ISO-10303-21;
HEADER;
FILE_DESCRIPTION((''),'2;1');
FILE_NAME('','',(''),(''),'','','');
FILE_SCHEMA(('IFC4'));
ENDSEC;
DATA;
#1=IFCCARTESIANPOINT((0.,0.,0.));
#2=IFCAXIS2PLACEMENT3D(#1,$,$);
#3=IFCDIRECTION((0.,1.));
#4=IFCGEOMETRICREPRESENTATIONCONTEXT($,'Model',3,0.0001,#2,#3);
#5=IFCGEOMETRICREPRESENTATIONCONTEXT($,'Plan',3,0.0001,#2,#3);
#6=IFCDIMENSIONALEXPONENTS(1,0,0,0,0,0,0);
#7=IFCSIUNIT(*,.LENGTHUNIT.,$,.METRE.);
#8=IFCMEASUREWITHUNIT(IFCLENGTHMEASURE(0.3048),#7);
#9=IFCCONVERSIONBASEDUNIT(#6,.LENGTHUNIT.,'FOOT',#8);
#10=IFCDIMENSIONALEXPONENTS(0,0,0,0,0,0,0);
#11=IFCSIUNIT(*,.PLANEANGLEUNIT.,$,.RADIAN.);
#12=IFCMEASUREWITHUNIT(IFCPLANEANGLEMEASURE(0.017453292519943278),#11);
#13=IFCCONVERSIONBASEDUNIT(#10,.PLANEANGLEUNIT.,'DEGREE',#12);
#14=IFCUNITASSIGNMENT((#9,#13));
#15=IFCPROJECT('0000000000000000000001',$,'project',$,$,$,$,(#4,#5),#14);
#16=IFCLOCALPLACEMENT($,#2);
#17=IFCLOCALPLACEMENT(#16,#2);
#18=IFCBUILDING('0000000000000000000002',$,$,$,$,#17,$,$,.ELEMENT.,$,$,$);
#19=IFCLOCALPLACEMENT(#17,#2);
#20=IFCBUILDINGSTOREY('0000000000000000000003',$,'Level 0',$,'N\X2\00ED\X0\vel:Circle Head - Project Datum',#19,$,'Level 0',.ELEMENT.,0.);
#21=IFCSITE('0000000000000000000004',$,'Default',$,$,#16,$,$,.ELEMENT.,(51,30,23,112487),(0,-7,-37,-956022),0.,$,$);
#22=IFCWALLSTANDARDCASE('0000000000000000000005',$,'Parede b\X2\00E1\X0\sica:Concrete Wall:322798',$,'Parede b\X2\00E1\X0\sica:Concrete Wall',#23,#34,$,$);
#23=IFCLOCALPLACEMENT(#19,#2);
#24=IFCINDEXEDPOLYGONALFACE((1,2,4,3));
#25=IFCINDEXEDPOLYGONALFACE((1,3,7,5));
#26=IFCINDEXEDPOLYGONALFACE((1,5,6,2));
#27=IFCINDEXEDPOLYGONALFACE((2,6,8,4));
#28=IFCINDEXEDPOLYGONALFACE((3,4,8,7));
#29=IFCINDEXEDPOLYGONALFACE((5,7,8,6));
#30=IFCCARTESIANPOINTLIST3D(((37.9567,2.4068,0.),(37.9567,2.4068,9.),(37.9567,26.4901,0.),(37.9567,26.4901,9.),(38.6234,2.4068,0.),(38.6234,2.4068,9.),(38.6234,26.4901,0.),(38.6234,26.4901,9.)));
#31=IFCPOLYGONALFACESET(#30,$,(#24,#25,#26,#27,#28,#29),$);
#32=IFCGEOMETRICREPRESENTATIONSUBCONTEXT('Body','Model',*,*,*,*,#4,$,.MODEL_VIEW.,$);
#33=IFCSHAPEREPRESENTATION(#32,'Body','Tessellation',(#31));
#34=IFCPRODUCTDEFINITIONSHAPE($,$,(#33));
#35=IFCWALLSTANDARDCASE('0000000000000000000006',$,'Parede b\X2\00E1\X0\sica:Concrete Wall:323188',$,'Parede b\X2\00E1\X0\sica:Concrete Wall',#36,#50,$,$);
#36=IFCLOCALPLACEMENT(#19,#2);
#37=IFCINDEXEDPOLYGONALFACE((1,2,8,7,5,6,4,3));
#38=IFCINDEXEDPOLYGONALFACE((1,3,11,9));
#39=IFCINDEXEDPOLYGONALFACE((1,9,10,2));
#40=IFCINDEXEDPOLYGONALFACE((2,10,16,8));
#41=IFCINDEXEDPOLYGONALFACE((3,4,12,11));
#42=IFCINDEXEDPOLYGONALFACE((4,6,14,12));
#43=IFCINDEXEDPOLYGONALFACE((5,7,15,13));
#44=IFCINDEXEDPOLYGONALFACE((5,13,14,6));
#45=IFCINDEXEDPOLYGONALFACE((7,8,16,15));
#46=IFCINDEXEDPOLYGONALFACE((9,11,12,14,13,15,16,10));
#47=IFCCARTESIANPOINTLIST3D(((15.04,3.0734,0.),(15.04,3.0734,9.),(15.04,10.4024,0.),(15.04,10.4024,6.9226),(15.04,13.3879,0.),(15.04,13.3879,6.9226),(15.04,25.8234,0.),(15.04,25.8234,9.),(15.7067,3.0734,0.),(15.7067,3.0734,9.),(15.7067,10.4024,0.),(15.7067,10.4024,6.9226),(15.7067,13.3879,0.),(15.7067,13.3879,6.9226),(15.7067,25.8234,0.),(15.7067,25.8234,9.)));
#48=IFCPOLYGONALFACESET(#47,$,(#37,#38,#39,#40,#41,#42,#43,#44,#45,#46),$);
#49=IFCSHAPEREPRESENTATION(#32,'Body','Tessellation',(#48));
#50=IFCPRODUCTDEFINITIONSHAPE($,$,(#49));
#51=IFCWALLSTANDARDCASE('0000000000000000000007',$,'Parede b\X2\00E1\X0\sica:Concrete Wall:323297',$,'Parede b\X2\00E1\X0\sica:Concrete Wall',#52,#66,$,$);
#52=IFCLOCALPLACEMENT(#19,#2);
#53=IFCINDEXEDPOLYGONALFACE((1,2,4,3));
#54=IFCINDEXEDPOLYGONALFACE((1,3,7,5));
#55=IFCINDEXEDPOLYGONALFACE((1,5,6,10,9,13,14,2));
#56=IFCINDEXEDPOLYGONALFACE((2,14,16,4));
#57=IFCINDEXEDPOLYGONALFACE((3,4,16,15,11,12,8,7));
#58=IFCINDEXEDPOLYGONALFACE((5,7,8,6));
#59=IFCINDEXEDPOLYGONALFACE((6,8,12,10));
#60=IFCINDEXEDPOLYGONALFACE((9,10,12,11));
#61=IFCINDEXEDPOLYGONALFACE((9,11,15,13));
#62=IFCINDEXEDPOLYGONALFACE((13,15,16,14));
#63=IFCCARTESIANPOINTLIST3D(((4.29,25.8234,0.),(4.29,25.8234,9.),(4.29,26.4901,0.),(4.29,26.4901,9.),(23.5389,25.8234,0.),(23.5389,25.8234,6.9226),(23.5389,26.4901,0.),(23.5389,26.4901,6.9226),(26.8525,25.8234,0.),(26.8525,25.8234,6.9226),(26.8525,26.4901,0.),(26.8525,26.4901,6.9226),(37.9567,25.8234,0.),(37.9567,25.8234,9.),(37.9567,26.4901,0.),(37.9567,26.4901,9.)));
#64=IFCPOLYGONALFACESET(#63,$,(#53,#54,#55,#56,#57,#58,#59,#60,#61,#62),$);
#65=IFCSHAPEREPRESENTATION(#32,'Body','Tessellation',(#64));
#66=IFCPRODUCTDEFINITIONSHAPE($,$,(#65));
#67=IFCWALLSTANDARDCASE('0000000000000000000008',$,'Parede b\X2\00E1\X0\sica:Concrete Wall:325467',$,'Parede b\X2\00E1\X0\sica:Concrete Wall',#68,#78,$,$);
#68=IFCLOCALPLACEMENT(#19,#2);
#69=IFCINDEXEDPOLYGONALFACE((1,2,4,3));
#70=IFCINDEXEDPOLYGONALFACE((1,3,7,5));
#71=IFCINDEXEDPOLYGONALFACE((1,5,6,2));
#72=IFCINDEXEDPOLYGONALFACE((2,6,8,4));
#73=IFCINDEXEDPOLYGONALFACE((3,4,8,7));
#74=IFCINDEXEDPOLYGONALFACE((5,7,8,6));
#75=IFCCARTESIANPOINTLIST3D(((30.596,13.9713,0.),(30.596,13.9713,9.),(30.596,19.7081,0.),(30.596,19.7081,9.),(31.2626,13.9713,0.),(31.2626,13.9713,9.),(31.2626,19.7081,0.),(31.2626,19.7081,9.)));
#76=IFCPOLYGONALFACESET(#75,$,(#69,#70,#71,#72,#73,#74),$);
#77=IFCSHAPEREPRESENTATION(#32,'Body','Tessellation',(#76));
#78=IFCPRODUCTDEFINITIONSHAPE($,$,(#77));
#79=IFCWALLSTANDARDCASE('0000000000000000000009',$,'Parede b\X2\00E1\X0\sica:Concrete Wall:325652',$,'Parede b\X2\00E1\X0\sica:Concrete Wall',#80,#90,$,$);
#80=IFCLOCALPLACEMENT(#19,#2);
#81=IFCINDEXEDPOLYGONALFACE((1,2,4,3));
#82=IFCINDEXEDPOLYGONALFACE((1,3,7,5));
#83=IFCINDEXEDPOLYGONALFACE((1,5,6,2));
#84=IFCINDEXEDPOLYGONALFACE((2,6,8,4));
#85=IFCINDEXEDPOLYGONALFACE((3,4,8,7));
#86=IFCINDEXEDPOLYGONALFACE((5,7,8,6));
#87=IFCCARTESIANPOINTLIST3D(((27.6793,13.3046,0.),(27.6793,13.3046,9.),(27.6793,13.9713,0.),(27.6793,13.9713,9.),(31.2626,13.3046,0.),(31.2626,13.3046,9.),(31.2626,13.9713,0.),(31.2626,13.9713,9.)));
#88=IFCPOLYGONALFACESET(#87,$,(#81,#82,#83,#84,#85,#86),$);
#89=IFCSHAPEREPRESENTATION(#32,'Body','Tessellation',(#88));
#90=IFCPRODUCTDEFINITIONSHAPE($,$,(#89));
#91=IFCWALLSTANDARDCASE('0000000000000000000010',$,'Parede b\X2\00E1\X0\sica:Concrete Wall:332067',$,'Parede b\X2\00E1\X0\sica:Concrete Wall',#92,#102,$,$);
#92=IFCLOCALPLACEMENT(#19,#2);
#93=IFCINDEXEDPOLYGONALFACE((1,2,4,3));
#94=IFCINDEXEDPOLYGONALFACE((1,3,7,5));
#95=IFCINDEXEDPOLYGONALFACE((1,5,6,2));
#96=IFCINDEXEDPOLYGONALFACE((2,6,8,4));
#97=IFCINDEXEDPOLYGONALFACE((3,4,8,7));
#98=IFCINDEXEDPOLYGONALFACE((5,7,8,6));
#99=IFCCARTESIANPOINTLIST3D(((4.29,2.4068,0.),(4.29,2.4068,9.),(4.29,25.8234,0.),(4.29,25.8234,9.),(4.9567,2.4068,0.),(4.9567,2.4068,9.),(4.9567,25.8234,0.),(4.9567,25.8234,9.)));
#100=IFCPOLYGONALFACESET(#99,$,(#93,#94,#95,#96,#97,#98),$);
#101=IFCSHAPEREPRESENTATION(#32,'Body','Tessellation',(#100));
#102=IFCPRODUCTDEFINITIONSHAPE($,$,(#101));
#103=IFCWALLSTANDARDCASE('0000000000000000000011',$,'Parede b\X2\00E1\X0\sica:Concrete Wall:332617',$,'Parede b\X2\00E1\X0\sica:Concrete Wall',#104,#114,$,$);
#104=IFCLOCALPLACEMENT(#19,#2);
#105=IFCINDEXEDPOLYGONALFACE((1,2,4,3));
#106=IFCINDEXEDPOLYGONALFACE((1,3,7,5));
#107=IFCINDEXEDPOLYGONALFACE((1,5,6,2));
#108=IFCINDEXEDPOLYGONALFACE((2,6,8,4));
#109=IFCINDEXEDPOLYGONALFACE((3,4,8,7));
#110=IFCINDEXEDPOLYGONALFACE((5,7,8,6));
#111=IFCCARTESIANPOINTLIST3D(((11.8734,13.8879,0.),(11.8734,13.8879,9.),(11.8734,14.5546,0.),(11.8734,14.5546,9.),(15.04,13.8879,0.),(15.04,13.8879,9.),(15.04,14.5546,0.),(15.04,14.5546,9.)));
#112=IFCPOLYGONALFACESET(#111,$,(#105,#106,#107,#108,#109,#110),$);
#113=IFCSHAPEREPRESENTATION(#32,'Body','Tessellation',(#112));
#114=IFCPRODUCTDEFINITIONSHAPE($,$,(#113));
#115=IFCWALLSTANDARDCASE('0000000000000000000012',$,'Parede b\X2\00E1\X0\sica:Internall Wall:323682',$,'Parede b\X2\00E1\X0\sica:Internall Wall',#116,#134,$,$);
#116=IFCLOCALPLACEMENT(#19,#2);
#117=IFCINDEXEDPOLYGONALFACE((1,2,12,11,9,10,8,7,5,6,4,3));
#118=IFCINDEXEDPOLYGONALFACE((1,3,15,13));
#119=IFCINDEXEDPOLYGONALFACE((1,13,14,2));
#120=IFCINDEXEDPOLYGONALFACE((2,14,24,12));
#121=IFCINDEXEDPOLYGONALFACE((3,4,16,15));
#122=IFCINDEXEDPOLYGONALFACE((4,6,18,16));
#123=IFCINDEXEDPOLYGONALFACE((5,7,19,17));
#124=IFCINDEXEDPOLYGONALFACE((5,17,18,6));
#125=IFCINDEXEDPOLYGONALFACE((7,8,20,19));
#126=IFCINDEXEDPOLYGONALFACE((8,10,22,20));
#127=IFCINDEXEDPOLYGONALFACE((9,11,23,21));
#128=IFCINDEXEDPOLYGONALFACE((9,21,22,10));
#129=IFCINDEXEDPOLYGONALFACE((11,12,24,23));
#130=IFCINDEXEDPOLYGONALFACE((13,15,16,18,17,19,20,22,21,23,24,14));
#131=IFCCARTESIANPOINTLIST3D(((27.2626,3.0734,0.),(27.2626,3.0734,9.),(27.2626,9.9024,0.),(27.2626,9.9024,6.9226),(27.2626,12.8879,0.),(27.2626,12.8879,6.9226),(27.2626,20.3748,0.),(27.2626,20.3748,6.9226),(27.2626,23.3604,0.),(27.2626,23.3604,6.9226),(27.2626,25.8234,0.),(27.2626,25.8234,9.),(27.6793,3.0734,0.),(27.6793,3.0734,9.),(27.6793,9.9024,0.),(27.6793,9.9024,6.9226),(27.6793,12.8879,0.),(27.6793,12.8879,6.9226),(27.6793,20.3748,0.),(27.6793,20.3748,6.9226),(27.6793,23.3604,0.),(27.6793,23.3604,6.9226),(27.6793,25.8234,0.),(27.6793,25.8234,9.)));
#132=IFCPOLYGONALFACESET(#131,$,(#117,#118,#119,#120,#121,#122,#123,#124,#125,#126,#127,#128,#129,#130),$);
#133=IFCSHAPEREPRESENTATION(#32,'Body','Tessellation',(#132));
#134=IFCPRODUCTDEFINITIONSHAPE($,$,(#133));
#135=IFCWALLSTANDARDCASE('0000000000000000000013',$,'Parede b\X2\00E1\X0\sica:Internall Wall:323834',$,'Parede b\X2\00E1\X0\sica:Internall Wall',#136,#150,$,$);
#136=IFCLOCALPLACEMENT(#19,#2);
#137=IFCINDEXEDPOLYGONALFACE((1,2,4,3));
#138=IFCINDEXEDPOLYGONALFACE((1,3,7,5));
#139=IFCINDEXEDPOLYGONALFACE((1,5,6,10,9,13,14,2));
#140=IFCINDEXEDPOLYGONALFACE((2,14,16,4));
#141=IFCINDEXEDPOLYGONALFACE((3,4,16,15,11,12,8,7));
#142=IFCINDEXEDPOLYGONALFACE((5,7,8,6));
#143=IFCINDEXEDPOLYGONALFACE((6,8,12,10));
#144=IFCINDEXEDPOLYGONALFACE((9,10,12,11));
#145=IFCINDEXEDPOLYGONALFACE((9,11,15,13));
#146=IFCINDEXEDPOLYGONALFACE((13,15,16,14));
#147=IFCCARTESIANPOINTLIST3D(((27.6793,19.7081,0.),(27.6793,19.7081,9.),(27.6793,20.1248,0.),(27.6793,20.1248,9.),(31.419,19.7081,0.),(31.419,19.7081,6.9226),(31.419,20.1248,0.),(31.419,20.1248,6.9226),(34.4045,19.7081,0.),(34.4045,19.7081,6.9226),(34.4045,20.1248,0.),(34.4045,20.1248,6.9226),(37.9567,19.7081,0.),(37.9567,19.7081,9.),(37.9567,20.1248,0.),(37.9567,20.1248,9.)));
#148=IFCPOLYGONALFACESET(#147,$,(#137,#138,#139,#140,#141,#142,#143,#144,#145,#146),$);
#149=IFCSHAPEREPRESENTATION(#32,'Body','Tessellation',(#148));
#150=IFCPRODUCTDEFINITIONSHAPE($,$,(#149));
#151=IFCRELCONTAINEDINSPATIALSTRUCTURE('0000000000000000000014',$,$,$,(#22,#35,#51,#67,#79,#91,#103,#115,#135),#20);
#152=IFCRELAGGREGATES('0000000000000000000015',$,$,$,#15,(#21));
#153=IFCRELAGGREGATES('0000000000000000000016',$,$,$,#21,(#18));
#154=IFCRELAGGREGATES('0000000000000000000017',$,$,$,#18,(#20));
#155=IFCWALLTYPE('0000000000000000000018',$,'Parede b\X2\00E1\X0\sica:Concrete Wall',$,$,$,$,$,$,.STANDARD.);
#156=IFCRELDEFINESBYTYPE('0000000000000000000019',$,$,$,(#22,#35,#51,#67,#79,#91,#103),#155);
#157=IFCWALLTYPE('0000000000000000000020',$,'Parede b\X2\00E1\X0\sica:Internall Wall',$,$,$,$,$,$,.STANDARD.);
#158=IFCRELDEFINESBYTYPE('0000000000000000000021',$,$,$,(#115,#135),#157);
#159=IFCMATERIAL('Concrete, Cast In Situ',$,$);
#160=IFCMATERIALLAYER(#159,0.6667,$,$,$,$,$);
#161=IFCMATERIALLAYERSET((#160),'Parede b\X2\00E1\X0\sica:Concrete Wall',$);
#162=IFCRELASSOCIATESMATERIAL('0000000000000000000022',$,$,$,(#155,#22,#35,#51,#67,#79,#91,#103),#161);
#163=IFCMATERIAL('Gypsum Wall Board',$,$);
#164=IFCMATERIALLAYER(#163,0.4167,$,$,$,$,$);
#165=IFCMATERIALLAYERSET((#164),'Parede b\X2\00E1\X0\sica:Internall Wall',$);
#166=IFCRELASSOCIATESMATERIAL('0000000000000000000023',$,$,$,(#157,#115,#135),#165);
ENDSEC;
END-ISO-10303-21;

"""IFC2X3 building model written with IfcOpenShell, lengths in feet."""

from ifc_helpers import new_model, entity, si_unit, converted_unit, direction, frame, frame_2d, origin, place, context, subcontext, project, spatial, rectangle, extrude, material, layer, layer_set, layer_usage, type_object, element, save


model = new_model("IFC2X3")

# Units and contexts
model_context = context("Model", 3, precision=0.0001, world=origin(), true_north=direction((0.0, 1.0)))
plan_context = context("Plan", 3, precision=0.0001, world=origin(), true_north=direction((0.0, 1.0)))
body_context = subcontext(model_context, "Body", "Model", "MODEL_VIEW")
ifc_project = project(units=[converted_unit("LENGTHUNIT", "FOOT", entity("IfcLengthMeasure", 0.3048), si_unit("LENGTHUNIT", "METRE"), dimensions=[1, 0, 0, 0, 0, 0, 0]), converted_unit("PLANEANGLEUNIT", "DEGREE", entity("IfcPlaneAngleMeasure", 0.017453292519943278), si_unit("PLANEANGLEUNIT", "RADIAN"), dimensions=[0, 0, 0, 0, 0, 0, 0])], contexts=[model_context, plan_context])

# Site, building, storey
site_placement = place(None, origin())
site = spatial("IfcSite", under=ifc_project, at=site_placement, Name="Default", CompositionType="ELEMENT", RefLatitude=(51, 30, 23, 112487), RefLongitude=(0, -7, -37, -956022), RefElevation=0.0)
building_placement = place(site_placement, origin())
building = spatial("IfcBuilding", under=site, at=building_placement, CompositionType="ELEMENT")
storey_placement = place(building_placement, origin())
storey = spatial("IfcBuildingStorey", under=building, at=storey_placement, Name="Level 0", ObjectType="Nível:Circle Head - Project Datum", LongName="Level 0", CompositionType="ELEMENT", Elevation=0.0)

# Wall
ifc_material_1 = material(Name="Concrete, Cast In Situ")
ifc_layer_1 = layer(ifc_material_1, 0.6667)
ifc_layer_set_1 = layer_set([ifc_layer_1], Name="Parede básica:Concrete Wall")
ifc_layer_usage_1 = layer_usage(ifc_layer_set_1, "AXIS2", "NEGATIVE", 0.3333)
wall_type_1 = type_object("IfcWallType", Name="Parede básica:Concrete Wall", PredefinedType="STANDARD", material=ifc_layer_set_1)
wall_1_placement = place(storey_placement, frame((38.29, 26.4901, 0.0), z_axis=(0.0, 0.0, 1.0), x_axis=(0.0, -1.0, 0.0)))
element("IfcWallStandardCase", 1, at=wall_1_placement, inside=storey, type_object=wall_type_1, material=ifc_layer_usage_1, Name="Parede básica:Concrete Wall:322798", ObjectType="Parede básica:Concrete Wall", context=body_context, shape_type="SweptSolid", body=[
    extrude(rectangle(XDim=24.0833, YDim=0.6667, at=frame_2d((12.0417, 0.0), x_axis=(-1.0, 0.0))), origin(), (0.0, 0.0, 1.0), 9.0),
])

# Walls, openings
ifc_layer_usage_2 = layer_usage(ifc_layer_set_1, "AXIS2", "NEGATIVE", 0.3333)
wall_2_placement = place(storey_placement, frame((15.3734, 3.0734, 0.0), z_axis=(0.0, 0.0, 1.0), x_axis=(0.0, 1.0, 0.0)))
wall_2 = element("IfcWallStandardCase", 2, at=wall_2_placement, inside=storey, type_object=wall_type_1, material=ifc_layer_usage_2, Name="Parede básica:Concrete Wall:323188", ObjectType="Parede básica:Concrete Wall", context=body_context, shape_type="SweptSolid", body=[
    extrude(rectangle(XDim=22.75, YDim=0.6667, at=frame_2d((11.375, 0.0), x_axis=(1.0, 0.0))), origin(), (0.0, 0.0, 1.0), 9.0),
])
opening_1_placement = place(wall_2_placement, frame((7.3289, -0.3333, 0.0)))
element("IfcOpeningElement", 3, at=opening_1_placement, cuts=wall_2, ObjectType="Opening", context=body_context, shape_type="SweptSolid", body=[
    extrude(rectangle(XDim=6.9226, YDim=2.9856, at=frame_2d((3.4613, 1.4928), x_axis=(1.0, 0.0))), frame((0.0, 0.0, 0.0), z_axis=(0.0, 1.0, 0.0), x_axis=(0.0, 0.0, 1.0)), (0.0, 0.0, 1.0), 0.6667),
])
ifc_layer_usage_3 = layer_usage(ifc_layer_set_1, "AXIS2", "NEGATIVE", 0.3333)
wall_3_placement = place(storey_placement, frame((4.29, 26.1568, 0.0)))
wall_3 = element("IfcWallStandardCase", 4, at=wall_3_placement, inside=storey, type_object=wall_type_1, material=ifc_layer_usage_3, Name="Parede básica:Concrete Wall:323297", ObjectType="Parede básica:Concrete Wall", context=body_context, shape_type="SweptSolid", body=[
    extrude(rectangle(XDim=33.6667, YDim=0.6667, at=frame_2d((16.8333, 0.0), x_axis=(1.0, 0.0))), origin(), (0.0, 0.0, 1.0), 9.0),
])
opening_2_placement = place(wall_3_placement, frame((22.5625, 0.3333, 0.0)))
element("IfcOpeningElement", 5, at=opening_2_placement, cuts=wall_3, ObjectType="Opening", context=body_context, shape_type="SweptSolid", body=[
    extrude(rectangle(XDim=6.9226, YDim=3.3136, at=frame_2d((3.4613, 1.6568), x_axis=(1.0, 0.0))), frame((0.0, 0.0, 0.0), z_axis=(0.0, -1.0, 0.0), x_axis=(0.0, 0.0, 1.0)), (0.0, 0.0, 1.0), 0.6667),
])

# Walls
ifc_layer_usage_4 = layer_usage(ifc_layer_set_1, "AXIS2", "NEGATIVE", 0.3333)
wall_4_placement = place(storey_placement, frame((30.9293, 19.7081, 0.0), z_axis=(0.0, 0.0, 1.0), x_axis=(0.0, -1.0, 0.0)))
element("IfcWallStandardCase", 6, at=wall_4_placement, inside=storey, type_object=wall_type_1, material=ifc_layer_usage_4, Name="Parede básica:Concrete Wall:325467", ObjectType="Parede básica:Concrete Wall", context=body_context, shape_type="SweptSolid", body=[
    extrude(rectangle(XDim=5.7369, YDim=0.6667, at=frame_2d((2.8684, 0.0), x_axis=(-1.0, 0.0))), origin(), (0.0, 0.0, 1.0), 9.0),
])
ifc_layer_usage_5 = layer_usage(ifc_layer_set_1, "AXIS2", "NEGATIVE", 0.3333)
wall_5_placement = place(storey_placement, frame((31.2626, 13.6379, 0.0), z_axis=(0.0, 0.0, 1.0), x_axis=(-1.0, 0.0, 0.0)))
element("IfcWallStandardCase", 7, at=wall_5_placement, inside=storey, type_object=wall_type_1, material=ifc_layer_usage_5, Name="Parede básica:Concrete Wall:325652", ObjectType="Parede básica:Concrete Wall", context=body_context, shape_type="SweptSolid", body=[
    extrude(rectangle(XDim=3.5833, YDim=0.6667, at=frame_2d((1.7917, 0.0), x_axis=(-1.0, 0.0))), origin(), (0.0, 0.0, 1.0), 9.0),
])
ifc_layer_usage_6 = layer_usage(ifc_layer_set_1, "AXIS2", "NEGATIVE", 0.3333)
wall_6_placement = place(storey_placement, frame((4.6234, 2.4068, 0.0), z_axis=(0.0, 0.0, 1.0), x_axis=(0.0, 1.0, 0.0)))
element("IfcWallStandardCase", 8, at=wall_6_placement, inside=storey, type_object=wall_type_1, material=ifc_layer_usage_6, Name="Parede básica:Concrete Wall:332067", ObjectType="Parede básica:Concrete Wall", context=body_context, shape_type="SweptSolid", body=[
    extrude(rectangle(XDim=23.4167, YDim=0.6667, at=frame_2d((11.7083, 0.0), x_axis=(-1.0, 0.0))), origin(), (0.0, 0.0, 1.0), 9.0),
])
ifc_layer_usage_7 = layer_usage(ifc_layer_set_1, "AXIS2", "NEGATIVE", 0.3333)
wall_7_placement = place(storey_placement, frame((15.04, 14.2213, 0.0), z_axis=(0.0, 0.0, 1.0), x_axis=(-1.0, 0.0, 0.0)))
element("IfcWallStandardCase", 9, at=wall_7_placement, inside=storey, type_object=wall_type_1, material=ifc_layer_usage_7, Name="Parede básica:Concrete Wall:332617", ObjectType="Parede básica:Concrete Wall", context=body_context, shape_type="SweptSolid", body=[
    extrude(rectangle(XDim=3.1667, YDim=0.6667, at=frame_2d((1.5833, 0.0), x_axis=(-1.0, 0.0))), origin(), (0.0, 0.0, 1.0), 9.0),
])

# Wall, openings
ifc_material_2 = material(Name="Gypsum Wall Board")
ifc_layer_2 = layer(ifc_material_2, 0.4167)
ifc_layer_set_2 = layer_set([ifc_layer_2], Name="Parede básica:Internall Wall")
ifc_layer_usage_8 = layer_usage(ifc_layer_set_2, "AXIS2", "POSITIVE", -0.2083)
wall_type_2 = type_object("IfcWallType", Name="Parede básica:Internall Wall", PredefinedType="STANDARD", material=ifc_layer_set_2)
wall_8_placement = place(storey_placement, frame((27.471, 3.0734, 0.0), z_axis=(0.0, 0.0, 1.0), x_axis=(0.0, 1.0, 0.0)))
wall_8 = element("IfcWallStandardCase", 10, at=wall_8_placement, inside=storey, type_object=wall_type_2, material=ifc_layer_usage_8, Name="Parede básica:Internall Wall:323682", ObjectType="Parede básica:Internall Wall", context=body_context, shape_type="SweptSolid", body=[
    extrude(rectangle(XDim=22.75, YDim=0.4167, at=frame_2d((11.375, 0.0), x_axis=(1.0, 0.0))), origin(), (0.0, 0.0, 1.0), 9.0),
])
opening_3_placement = place(wall_8_placement, frame((20.2869, 0.2083, 0.0)))
element("IfcOpeningElement", 11, at=opening_3_placement, cuts=wall_8, ObjectType="Opening", context=body_context, shape_type="SweptSolid", body=[
    extrude(rectangle(XDim=6.9226, YDim=2.9856, at=frame_2d((3.4613, 1.4928), x_axis=(1.0, 0.0))), frame((0.0, 0.0, 0.0), z_axis=(0.0, -1.0, 0.0), x_axis=(0.0, 0.0, 1.0)), (0.0, 0.0, 1.0), 0.4167),
])
opening_4_placement = place(wall_8_placement, frame((9.8145, 0.2083, 0.0)))
element("IfcOpeningElement", 12, at=opening_4_placement, cuts=wall_8, ObjectType="Opening", context=body_context, shape_type="SweptSolid", body=[
    extrude(rectangle(XDim=6.9226, YDim=2.9856, at=frame_2d((3.4613, 1.4928), x_axis=(1.0, 0.0))), frame((0.0, 0.0, 0.0), z_axis=(0.0, -1.0, 0.0), x_axis=(0.0, 0.0, 1.0)), (0.0, 0.0, 1.0), 0.4167),
])

# Wall, opening
ifc_layer_usage_9 = layer_usage(ifc_layer_set_2, "AXIS2", "POSITIVE", -0.2083)
wall_9_placement = place(storey_placement, frame((37.9567, 19.9165, 0.0), z_axis=(0.0, 0.0, 1.0), x_axis=(-1.0, 0.0, 0.0)))
wall_9 = element("IfcWallStandardCase", 13, at=wall_9_placement, inside=storey, type_object=wall_type_2, material=ifc_layer_usage_9, Name="Parede básica:Internall Wall:323834", ObjectType="Parede básica:Internall Wall", context=body_context, shape_type="SweptSolid", body=[
    extrude(rectangle(XDim=10.2774, YDim=0.4167, at=frame_2d((5.1387, 0.0), x_axis=(1.0, 0.0))), origin(), (0.0, 0.0, 1.0), 9.0),
])
opening_5_placement = place(wall_9_placement, frame((3.5522, -0.2083, 0.0)))
element("IfcOpeningElement", 14, at=opening_5_placement, cuts=wall_9, ObjectType="Opening", context=body_context, shape_type="SweptSolid", body=[
    extrude(rectangle(XDim=6.9226, YDim=2.9856, at=frame_2d((3.4613, 1.4928), x_axis=(1.0, 0.0))), frame((0.0, 0.0, 0.0), z_axis=(0.0, 1.0, 0.0), x_axis=(0.0, 0.0, 1.0)), (0.0, 0.0, 1.0), 0.4167),
])

save(model, "model.ifc")
